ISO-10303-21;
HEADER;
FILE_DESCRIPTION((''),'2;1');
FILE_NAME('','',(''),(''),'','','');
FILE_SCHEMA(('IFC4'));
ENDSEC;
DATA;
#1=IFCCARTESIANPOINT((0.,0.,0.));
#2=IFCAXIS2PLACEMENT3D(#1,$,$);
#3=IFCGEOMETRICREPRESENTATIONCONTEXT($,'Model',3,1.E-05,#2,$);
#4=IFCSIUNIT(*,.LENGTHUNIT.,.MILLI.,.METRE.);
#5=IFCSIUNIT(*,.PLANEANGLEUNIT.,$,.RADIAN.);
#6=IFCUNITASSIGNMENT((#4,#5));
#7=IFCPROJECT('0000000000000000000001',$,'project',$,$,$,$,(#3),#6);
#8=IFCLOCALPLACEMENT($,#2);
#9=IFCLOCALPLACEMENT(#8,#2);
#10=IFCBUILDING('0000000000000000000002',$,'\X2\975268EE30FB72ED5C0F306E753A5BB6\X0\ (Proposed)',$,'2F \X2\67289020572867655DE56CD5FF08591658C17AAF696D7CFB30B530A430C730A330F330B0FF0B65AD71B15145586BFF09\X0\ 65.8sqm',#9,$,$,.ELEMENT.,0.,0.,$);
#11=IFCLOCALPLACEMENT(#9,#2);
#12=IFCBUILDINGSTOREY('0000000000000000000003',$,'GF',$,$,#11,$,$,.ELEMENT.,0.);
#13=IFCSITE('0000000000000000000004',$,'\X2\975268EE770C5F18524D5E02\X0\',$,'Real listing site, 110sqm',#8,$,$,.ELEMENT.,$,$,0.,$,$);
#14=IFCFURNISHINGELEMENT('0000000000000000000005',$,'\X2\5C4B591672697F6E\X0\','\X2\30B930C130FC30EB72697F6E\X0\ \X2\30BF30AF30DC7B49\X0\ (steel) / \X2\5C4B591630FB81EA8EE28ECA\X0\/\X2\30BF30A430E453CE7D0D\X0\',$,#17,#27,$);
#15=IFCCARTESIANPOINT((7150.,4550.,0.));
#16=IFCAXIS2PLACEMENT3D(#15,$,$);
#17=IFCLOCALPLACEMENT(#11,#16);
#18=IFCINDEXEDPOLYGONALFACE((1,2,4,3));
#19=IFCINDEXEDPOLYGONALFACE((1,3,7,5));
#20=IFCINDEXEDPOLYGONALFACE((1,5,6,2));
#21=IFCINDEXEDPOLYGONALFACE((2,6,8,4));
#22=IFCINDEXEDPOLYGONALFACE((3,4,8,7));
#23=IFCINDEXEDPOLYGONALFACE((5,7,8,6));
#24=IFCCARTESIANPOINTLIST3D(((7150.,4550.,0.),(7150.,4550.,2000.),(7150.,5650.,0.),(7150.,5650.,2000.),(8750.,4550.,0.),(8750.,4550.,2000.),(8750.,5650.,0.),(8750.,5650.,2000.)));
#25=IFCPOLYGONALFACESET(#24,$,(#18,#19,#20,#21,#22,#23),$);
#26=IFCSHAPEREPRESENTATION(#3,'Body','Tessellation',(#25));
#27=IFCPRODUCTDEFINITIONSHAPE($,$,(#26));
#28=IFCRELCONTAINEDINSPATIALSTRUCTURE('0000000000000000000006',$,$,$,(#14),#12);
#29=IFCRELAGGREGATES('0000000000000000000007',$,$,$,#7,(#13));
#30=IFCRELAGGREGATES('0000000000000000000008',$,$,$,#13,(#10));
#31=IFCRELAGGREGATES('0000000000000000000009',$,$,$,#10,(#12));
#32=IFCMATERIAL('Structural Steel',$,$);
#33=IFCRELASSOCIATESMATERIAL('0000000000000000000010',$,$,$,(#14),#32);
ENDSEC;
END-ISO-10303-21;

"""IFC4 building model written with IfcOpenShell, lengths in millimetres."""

from ifc_helpers import new_model, si_unit, frame, frame_2d, origin, place, context, project, spatial, rectangle, extrude, material, element, save


model = new_model("IFC4")

# Units and contexts
model_context = context("Model", 3, precision=1e-05, world=origin())
ifc_project = project(units=[si_unit("LENGTHUNIT", "METRE", prefix="MILLI"), si_unit("PLANEANGLEUNIT", "RADIAN")], contexts=[model_context])

# Site, building, storey
site_placement = place(None, origin())
site = spatial("IfcSite", under=ifc_project, at=site_placement, Name="青森県弘前市", ObjectType="Real listing site, 110sqm", CompositionType="ELEMENT", RefElevation=0.0)
building_placement = place(site_placement, origin())
building = spatial("IfcBuilding", under=site, at=building_placement, Name="青森・狭小の町家 (Proposed)", ObjectType="2F 木造在来工法（外壁窯業系サイディング＋断熱充填） 65.8sqm", CompositionType="ELEMENT", ElevationOfRefHeight=0.0, ElevationOfTerrain=0.0)
storey_placement = place(building_placement, origin())
storey = spatial("IfcBuildingStorey", under=building, at=storey_placement, Name="GF", CompositionType="ELEMENT", Elevation=0.0)

# Shared definitions
ifc_material_1 = material(Name="Structural Steel")

# Furnishing element
furnishing_1_placement = place(storey_placement, frame((7150.0, 4550.0, 0.0)))
element("IfcFurnishingElement", 1, at=furnishing_1_placement, inside=storey, material=ifc_material_1, Name="屋外物置", Description="スチール物置 タクボ等 (steel) / 屋外・自転車/タイヤ収納", context=model_context, shape_type="SweptSolid", body=[
    extrude(rectangle(XDim=1600.0, YDim=1100.0, at=frame_2d((800.0, 550.0))), frame((7150.0, 4550.0, 0.0)), (0.0, 0.0, 1.0), 2000.0),
])

save(model, "model.ifc")
